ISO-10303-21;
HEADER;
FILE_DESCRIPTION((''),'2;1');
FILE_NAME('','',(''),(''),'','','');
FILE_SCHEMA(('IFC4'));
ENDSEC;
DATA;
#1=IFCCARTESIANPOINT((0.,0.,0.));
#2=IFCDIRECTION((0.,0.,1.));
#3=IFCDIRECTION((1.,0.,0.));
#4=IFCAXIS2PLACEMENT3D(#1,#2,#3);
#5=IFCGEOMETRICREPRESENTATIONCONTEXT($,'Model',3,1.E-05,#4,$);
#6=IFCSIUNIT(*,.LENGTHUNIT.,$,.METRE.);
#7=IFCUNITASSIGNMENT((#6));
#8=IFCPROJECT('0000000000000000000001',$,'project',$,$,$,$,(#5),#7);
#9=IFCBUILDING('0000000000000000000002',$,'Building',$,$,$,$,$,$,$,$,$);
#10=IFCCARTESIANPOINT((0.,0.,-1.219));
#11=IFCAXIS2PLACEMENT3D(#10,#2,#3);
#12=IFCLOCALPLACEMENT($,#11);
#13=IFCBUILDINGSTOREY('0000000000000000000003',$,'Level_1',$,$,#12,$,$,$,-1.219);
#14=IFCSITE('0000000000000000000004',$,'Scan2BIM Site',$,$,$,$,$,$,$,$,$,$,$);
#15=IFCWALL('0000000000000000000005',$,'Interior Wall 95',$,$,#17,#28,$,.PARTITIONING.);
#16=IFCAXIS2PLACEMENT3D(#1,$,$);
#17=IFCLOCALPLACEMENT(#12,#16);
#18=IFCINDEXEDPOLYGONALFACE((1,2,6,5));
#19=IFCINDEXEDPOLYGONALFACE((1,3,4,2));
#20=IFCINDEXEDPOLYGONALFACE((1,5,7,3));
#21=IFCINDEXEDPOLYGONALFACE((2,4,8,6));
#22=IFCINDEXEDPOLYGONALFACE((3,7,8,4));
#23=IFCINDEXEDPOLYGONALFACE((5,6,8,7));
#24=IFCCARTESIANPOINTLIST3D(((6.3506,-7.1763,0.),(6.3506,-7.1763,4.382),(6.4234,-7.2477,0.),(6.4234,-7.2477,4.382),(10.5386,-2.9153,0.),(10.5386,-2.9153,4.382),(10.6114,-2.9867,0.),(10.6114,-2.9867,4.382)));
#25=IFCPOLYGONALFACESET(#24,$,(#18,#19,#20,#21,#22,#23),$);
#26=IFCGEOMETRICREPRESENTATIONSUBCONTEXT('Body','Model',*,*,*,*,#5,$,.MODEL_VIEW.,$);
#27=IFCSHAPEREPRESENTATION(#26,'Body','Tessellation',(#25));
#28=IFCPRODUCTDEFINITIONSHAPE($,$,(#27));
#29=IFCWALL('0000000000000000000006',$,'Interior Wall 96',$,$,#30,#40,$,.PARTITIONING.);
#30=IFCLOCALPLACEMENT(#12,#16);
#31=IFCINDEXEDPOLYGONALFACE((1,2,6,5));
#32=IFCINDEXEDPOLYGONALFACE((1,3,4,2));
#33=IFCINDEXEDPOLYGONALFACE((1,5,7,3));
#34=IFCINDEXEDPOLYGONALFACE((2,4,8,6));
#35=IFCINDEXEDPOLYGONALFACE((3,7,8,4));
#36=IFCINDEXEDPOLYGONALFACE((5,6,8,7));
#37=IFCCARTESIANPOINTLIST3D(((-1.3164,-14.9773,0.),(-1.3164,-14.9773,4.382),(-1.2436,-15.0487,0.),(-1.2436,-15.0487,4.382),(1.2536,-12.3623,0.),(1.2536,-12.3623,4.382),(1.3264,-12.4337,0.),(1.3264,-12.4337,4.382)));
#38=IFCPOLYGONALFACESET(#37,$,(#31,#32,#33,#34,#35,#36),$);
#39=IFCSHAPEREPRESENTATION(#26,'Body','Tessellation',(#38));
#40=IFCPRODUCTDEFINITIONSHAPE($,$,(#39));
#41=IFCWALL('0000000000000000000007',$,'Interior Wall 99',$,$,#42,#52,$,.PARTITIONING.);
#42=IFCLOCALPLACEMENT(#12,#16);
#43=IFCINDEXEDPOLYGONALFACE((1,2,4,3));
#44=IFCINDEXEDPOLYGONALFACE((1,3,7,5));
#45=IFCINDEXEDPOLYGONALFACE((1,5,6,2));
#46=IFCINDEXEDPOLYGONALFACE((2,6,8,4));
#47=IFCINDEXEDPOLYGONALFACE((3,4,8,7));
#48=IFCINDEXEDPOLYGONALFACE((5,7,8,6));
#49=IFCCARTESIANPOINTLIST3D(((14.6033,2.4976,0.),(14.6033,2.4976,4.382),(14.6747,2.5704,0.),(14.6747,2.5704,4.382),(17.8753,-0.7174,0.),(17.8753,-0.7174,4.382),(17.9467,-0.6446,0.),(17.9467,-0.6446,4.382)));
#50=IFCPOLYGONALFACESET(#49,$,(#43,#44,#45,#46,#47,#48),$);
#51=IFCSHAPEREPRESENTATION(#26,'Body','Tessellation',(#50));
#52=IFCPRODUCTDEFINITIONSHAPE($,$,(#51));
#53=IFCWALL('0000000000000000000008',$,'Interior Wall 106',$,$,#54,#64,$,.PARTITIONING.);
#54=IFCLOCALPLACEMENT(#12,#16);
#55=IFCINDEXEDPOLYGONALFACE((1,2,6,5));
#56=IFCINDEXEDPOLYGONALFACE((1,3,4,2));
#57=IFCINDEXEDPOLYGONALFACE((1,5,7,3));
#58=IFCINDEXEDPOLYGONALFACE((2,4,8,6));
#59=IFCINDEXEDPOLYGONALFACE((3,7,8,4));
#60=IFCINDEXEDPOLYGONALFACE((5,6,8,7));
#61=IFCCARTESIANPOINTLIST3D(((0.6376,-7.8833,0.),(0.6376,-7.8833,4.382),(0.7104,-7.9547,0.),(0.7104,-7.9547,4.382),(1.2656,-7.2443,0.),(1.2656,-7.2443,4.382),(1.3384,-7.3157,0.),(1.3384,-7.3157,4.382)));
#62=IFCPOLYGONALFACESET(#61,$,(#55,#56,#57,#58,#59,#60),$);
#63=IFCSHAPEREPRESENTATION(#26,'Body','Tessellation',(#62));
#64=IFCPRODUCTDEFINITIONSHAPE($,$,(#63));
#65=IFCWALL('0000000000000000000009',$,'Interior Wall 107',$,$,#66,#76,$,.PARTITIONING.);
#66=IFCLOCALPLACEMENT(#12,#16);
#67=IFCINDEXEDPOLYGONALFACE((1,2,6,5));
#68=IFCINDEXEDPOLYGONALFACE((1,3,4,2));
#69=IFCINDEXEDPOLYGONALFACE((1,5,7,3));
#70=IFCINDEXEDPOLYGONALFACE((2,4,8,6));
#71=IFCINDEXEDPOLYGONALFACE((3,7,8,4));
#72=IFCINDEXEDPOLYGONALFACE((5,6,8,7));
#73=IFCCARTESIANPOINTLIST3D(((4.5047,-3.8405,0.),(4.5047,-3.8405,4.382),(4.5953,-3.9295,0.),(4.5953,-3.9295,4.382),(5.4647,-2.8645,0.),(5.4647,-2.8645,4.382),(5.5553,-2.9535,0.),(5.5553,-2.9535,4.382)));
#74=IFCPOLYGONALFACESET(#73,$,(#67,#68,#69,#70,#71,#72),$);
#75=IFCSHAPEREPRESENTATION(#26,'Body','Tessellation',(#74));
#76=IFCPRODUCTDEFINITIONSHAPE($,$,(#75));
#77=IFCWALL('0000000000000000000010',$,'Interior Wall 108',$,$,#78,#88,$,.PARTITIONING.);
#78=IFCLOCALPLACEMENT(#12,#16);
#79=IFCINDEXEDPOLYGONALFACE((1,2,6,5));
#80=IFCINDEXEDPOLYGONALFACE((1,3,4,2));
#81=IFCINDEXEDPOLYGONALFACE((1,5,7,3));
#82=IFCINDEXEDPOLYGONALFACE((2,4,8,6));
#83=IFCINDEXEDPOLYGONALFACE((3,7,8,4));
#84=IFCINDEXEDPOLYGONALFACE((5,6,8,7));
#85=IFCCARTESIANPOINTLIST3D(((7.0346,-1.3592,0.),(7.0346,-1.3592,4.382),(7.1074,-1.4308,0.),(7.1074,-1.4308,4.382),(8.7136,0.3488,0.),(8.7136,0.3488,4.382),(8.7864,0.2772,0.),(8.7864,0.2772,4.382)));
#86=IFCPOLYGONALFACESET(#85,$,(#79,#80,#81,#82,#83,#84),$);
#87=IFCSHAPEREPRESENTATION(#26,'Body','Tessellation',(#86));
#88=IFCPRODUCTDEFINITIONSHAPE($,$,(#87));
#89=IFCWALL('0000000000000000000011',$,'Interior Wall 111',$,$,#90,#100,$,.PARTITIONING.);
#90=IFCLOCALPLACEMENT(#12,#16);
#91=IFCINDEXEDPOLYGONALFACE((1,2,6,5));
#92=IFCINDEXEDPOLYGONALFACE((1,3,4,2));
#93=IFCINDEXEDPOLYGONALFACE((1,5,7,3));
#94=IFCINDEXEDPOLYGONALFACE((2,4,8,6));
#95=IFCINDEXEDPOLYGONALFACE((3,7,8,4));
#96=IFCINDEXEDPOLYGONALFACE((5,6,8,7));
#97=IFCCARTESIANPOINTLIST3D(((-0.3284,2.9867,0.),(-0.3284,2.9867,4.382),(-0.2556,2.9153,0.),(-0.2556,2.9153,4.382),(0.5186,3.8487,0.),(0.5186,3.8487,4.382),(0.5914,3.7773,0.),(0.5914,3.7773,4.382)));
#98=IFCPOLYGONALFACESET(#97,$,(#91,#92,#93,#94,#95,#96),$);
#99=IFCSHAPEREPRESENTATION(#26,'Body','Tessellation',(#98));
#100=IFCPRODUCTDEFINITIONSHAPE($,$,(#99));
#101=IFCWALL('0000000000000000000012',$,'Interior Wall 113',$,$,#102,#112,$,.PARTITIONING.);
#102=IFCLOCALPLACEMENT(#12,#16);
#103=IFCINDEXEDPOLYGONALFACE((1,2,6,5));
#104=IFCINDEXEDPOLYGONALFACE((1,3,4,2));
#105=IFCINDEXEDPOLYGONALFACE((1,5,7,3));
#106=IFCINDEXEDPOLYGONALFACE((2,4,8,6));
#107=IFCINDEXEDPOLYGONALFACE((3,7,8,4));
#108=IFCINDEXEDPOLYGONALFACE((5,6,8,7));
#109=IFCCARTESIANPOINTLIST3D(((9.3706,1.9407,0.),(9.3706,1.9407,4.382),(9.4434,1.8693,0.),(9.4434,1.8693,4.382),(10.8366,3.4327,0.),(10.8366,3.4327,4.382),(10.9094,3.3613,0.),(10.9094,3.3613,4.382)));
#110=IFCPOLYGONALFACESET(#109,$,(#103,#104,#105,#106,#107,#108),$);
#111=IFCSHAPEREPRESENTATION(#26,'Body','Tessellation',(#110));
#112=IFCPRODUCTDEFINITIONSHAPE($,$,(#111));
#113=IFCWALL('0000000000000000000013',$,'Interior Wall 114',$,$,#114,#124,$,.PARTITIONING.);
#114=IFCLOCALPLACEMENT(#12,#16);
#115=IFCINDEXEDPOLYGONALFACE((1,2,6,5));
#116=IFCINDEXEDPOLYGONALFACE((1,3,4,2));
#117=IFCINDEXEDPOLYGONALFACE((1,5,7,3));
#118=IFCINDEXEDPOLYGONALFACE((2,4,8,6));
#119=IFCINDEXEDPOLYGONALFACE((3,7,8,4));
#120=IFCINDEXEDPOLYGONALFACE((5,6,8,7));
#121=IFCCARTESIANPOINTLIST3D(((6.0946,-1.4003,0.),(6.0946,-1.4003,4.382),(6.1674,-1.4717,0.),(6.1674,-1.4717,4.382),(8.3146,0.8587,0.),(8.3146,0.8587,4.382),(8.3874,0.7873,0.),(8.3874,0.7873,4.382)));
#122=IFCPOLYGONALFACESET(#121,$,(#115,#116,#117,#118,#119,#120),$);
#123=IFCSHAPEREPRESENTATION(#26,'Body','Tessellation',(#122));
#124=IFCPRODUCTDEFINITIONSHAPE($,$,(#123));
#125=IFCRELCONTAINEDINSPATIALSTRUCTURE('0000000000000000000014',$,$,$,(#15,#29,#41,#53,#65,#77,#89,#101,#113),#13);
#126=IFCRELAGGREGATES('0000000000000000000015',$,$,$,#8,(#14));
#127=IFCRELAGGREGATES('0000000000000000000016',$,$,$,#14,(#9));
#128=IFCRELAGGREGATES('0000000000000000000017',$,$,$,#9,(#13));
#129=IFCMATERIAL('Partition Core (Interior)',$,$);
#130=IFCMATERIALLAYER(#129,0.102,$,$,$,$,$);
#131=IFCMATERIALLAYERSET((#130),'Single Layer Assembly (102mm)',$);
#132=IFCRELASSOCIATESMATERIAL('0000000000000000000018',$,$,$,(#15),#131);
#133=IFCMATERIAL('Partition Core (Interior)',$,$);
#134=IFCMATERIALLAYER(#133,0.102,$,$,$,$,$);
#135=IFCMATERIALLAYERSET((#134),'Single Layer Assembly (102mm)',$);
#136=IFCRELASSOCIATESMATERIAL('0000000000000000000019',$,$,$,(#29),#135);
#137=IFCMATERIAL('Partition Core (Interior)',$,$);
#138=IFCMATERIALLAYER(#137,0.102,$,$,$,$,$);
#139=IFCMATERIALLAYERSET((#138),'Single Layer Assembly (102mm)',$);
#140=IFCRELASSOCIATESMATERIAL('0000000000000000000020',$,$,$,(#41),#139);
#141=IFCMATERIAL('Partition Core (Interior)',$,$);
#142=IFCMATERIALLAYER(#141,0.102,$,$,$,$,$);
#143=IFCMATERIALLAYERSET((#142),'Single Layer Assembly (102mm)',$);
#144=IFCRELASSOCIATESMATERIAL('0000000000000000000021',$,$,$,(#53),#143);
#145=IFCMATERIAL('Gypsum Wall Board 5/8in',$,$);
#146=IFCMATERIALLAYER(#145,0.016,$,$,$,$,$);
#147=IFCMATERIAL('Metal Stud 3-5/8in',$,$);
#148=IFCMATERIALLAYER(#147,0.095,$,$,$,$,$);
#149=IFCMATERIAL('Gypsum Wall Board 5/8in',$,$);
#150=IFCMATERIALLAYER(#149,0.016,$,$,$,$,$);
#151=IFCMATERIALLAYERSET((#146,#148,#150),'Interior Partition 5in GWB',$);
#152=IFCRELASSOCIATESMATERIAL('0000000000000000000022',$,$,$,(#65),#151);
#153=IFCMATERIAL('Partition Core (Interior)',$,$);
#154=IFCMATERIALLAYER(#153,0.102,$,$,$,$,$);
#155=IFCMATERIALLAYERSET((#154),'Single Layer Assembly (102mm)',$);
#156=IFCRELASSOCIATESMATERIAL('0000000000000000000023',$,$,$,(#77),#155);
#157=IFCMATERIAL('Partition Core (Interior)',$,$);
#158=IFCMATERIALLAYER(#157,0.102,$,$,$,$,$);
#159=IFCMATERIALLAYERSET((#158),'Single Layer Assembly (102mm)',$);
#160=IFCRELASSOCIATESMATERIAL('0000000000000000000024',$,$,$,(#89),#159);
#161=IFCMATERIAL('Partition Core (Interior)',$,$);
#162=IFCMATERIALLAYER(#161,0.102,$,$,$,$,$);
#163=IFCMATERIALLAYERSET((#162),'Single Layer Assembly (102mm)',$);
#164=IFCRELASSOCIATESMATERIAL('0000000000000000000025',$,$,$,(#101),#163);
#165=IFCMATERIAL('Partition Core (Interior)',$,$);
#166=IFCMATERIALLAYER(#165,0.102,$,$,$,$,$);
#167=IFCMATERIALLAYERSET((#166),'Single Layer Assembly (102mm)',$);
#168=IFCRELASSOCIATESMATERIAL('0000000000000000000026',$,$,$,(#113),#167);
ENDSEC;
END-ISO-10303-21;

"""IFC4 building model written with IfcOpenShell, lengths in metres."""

from ifc_helpers import new_model, si_unit, frame, origin, origin_with_axes, place, context, subcontext, project, spatial, rectangle, extrude, material, layer, layer_set, element, save


model = new_model("IFC4")

# Units and contexts
model_context = context("Model", 3, precision=1e-05, world=origin_with_axes())
body_context = subcontext(model_context, "Body", "Model", "MODEL_VIEW")
ifc_project = project(units=[si_unit("LENGTHUNIT", "METRE")], contexts=[model_context])

# Site, building, storey
site = spatial("IfcSite", under=ifc_project, Name="Scan2BIM Site")
building = spatial("IfcBuilding", under=site, Name="Building")
storey_placement = place(None, frame((0.0, 0.0, -1.219), z_axis=(0.0, 0.0, 1.0), x_axis=(1.0, 0.0, 0.0)))
storey = spatial("IfcBuildingStorey", under=building, at=storey_placement, Name="Level_1", Elevation=-1.219)

# Walls
ifc_material_1 = material(Name="Partition Core (Interior)")
ifc_layer_1 = layer(ifc_material_1, 0.102)
ifc_layer_set_1 = layer_set([ifc_layer_1], Name="Single Layer Assembly (102mm)")
wall_1_placement = place(storey_placement, frame((8.481, -5.0815, 0.0), z_axis=(0.0, 0.0, 1.0), x_axis=(-0.700971, -0.71319, 0.0)))
element("IfcWall", 1, at=wall_1_placement, inside=storey, material=ifc_layer_set_1, Name="Interior Wall 95", PredefinedType="PARTITIONING", context=body_context, shape_type="SweptSolid", body=[
    extrude(rectangle(XDim=5.9746, YDim=0.102), origin(), (0.0, 0.0, 1.0), 4.382),
])
ifc_material_2 = material(Name="Partition Core (Interior)")
ifc_layer_2 = layer(ifc_material_2, 0.102)
ifc_layer_set_2 = layer_set([ifc_layer_2], Name="Single Layer Assembly (102mm)")
wall_2_placement = place(storey_placement, frame((0.005, -13.7055, 0.0), z_axis=(0.0, 0.0, 1.0), x_axis=(-0.700943, -0.713217, 0.0)))
element("IfcWall", 2, at=wall_2_placement, inside=storey, material=ifc_layer_set_2, Name="Interior Wall 96", PredefinedType="PARTITIONING", context=body_context, shape_type="SweptSolid", body=[
    extrude(rectangle(XDim=3.6665, YDim=0.102), origin(), (0.0, 0.0, 1.0), 4.382),
])
ifc_material_3 = material(Name="Partition Core (Interior)")
ifc_layer_3 = layer(ifc_material_3, 0.102)
ifc_layer_set_3 = layer_set([ifc_layer_3], Name="Single Layer Assembly (102mm)")
wall_3_placement = place(storey_placement, frame((16.275, 0.9265, 0.0), z_axis=(0.0, 0.0, 1.0), x_axis=(0.713292, -0.700867, 0.0)))
element("IfcWall", 3, at=wall_3_placement, inside=storey, material=ifc_layer_set_3, Name="Interior Wall 99", PredefinedType="PARTITIONING", context=body_context, shape_type="SweptSolid", body=[
    extrude(rectangle(XDim=4.5872, YDim=0.102), origin(), (0.0, 0.0, 1.0), 4.382),
])
ifc_material_4 = material(Name="Partition Core (Interior)")
ifc_layer_4 = layer(ifc_material_4, 0.102)
ifc_layer_set_4 = layer_set([ifc_layer_4], Name="Single Layer Assembly (102mm)")
wall_4_placement = place(storey_placement, frame((0.988, -7.5995, 0.0), z_axis=(0.0, 0.0, 1.0), x_axis=(0.700941, 0.713219, 0.0)))
element("IfcWall", 4, at=wall_4_placement, inside=storey, material=ifc_layer_set_4, Name="Interior Wall 106", PredefinedType="PARTITIONING", context=body_context, shape_type="SweptSolid", body=[
    extrude(rectangle(XDim=0.8959, YDim=0.102), origin(), (0.0, 0.0, 1.0), 4.382),
])
ifc_material_5 = material(Name="Gypsum Wall Board 5/8in")
ifc_layer_5 = layer(ifc_material_5, 0.016)
ifc_material_6 = material(Name="Metal Stud 3-5/8in")
ifc_layer_6 = layer(ifc_material_6, 0.095)
ifc_material_7 = material(Name="Gypsum Wall Board 5/8in")
ifc_layer_7 = layer(ifc_material_7, 0.016)
ifc_layer_set_5 = layer_set([ifc_layer_5, ifc_layer_6, ifc_layer_7], Name="Interior Partition 5in GWB")
wall_5_placement = place(storey_placement, frame((5.03, -3.397, 0.0), z_axis=(0.0, 0.0, 1.0), x_axis=(0.701239, 0.712926, 0.0)))
element("IfcWall", 5, at=wall_5_placement, inside=storey, material=ifc_layer_set_5, Name="Interior Wall 107", PredefinedType="PARTITIONING", context=body_context, shape_type="SweptSolid", body=[
    extrude(rectangle(XDim=1.369, YDim=0.127), origin(), (0.0, 0.0, 1.0), 4.382),
])
ifc_material_8 = material(Name="Partition Core (Interior)")
ifc_layer_8 = layer(ifc_material_8, 0.102)
ifc_layer_set_6 = layer_set([ifc_layer_8], Name="Single Layer Assembly (102mm)")
wall_6_placement = place(storey_placement, frame((7.9105, -0.541, 0.0), z_axis=(0.0, 0.0, 1.0), x_axis=(0.701027, 0.713135, 0.0)))
element("IfcWall", 6, at=wall_6_placement, inside=storey, material=ifc_layer_set_6, Name="Interior Wall 108", PredefinedType="PARTITIONING", context=body_context, shape_type="SweptSolid", body=[
    extrude(rectangle(XDim=2.3951, YDim=0.102), origin(), (0.0, 0.0, 1.0), 4.382),
])
ifc_material_9 = material(Name="Partition Core (Interior)")
ifc_layer_9 = layer(ifc_material_9, 0.102)
ifc_layer_set_7 = layer_set([ifc_layer_9], Name="Single Layer Assembly (102mm)")
wall_7_placement = place(storey_placement, frame((0.1315, 3.382, 0.0), z_axis=(0.0, 0.0, 1.0), x_axis=(-0.700873, -0.713286, 0.0)))
element("IfcWall", 7, at=wall_7_placement, inside=storey, material=ifc_layer_set_7, Name="Interior Wall 111", PredefinedType="PARTITIONING", context=body_context, shape_type="SweptSolid", body=[
    extrude(rectangle(XDim=1.2085, YDim=0.102), origin(), (0.0, 0.0, 1.0), 4.382),
])
ifc_material_10 = material(Name="Partition Core (Interior)")
ifc_layer_10 = layer(ifc_material_10, 0.102)
ifc_layer_set_8 = layer_set([ifc_layer_10], Name="Single Layer Assembly (102mm)")
wall_8_placement = place(storey_placement, frame((10.14, 2.651, 0.0), z_axis=(0.0, 0.0, 1.0), x_axis=(-0.700864, -0.713295, 0.0)))
element("IfcWall", 8, at=wall_8_placement, inside=storey, material=ifc_layer_set_8, Name="Interior Wall 113", PredefinedType="PARTITIONING", context=body_context, shape_type="SweptSolid", body=[
    extrude(rectangle(XDim=2.0917, YDim=0.102), origin(), (0.0, 0.0, 1.0), 4.382),
])
ifc_material_11 = material(Name="Partition Core (Interior)")
ifc_layer_11 = layer(ifc_material_11, 0.102)
ifc_layer_set_9 = layer_set([ifc_layer_11], Name="Single Layer Assembly (102mm)")
wall_9_placement = place(storey_placement, frame((7.241, -0.3065, 0.0), z_axis=(0.0, 0.0, 1.0), x_axis=(-0.700923, -0.713237, 0.0)))
element("IfcWall", 9, at=wall_9_placement, inside=storey, material=ifc_layer_set_9, Name="Interior Wall 114", PredefinedType="PARTITIONING", context=body_context, shape_type="SweptSolid", body=[
    extrude(rectangle(XDim=3.1673, YDim=0.102), origin(), (0.0, 0.0, 1.0), 4.382),
])

save(model, "model.ifc")
